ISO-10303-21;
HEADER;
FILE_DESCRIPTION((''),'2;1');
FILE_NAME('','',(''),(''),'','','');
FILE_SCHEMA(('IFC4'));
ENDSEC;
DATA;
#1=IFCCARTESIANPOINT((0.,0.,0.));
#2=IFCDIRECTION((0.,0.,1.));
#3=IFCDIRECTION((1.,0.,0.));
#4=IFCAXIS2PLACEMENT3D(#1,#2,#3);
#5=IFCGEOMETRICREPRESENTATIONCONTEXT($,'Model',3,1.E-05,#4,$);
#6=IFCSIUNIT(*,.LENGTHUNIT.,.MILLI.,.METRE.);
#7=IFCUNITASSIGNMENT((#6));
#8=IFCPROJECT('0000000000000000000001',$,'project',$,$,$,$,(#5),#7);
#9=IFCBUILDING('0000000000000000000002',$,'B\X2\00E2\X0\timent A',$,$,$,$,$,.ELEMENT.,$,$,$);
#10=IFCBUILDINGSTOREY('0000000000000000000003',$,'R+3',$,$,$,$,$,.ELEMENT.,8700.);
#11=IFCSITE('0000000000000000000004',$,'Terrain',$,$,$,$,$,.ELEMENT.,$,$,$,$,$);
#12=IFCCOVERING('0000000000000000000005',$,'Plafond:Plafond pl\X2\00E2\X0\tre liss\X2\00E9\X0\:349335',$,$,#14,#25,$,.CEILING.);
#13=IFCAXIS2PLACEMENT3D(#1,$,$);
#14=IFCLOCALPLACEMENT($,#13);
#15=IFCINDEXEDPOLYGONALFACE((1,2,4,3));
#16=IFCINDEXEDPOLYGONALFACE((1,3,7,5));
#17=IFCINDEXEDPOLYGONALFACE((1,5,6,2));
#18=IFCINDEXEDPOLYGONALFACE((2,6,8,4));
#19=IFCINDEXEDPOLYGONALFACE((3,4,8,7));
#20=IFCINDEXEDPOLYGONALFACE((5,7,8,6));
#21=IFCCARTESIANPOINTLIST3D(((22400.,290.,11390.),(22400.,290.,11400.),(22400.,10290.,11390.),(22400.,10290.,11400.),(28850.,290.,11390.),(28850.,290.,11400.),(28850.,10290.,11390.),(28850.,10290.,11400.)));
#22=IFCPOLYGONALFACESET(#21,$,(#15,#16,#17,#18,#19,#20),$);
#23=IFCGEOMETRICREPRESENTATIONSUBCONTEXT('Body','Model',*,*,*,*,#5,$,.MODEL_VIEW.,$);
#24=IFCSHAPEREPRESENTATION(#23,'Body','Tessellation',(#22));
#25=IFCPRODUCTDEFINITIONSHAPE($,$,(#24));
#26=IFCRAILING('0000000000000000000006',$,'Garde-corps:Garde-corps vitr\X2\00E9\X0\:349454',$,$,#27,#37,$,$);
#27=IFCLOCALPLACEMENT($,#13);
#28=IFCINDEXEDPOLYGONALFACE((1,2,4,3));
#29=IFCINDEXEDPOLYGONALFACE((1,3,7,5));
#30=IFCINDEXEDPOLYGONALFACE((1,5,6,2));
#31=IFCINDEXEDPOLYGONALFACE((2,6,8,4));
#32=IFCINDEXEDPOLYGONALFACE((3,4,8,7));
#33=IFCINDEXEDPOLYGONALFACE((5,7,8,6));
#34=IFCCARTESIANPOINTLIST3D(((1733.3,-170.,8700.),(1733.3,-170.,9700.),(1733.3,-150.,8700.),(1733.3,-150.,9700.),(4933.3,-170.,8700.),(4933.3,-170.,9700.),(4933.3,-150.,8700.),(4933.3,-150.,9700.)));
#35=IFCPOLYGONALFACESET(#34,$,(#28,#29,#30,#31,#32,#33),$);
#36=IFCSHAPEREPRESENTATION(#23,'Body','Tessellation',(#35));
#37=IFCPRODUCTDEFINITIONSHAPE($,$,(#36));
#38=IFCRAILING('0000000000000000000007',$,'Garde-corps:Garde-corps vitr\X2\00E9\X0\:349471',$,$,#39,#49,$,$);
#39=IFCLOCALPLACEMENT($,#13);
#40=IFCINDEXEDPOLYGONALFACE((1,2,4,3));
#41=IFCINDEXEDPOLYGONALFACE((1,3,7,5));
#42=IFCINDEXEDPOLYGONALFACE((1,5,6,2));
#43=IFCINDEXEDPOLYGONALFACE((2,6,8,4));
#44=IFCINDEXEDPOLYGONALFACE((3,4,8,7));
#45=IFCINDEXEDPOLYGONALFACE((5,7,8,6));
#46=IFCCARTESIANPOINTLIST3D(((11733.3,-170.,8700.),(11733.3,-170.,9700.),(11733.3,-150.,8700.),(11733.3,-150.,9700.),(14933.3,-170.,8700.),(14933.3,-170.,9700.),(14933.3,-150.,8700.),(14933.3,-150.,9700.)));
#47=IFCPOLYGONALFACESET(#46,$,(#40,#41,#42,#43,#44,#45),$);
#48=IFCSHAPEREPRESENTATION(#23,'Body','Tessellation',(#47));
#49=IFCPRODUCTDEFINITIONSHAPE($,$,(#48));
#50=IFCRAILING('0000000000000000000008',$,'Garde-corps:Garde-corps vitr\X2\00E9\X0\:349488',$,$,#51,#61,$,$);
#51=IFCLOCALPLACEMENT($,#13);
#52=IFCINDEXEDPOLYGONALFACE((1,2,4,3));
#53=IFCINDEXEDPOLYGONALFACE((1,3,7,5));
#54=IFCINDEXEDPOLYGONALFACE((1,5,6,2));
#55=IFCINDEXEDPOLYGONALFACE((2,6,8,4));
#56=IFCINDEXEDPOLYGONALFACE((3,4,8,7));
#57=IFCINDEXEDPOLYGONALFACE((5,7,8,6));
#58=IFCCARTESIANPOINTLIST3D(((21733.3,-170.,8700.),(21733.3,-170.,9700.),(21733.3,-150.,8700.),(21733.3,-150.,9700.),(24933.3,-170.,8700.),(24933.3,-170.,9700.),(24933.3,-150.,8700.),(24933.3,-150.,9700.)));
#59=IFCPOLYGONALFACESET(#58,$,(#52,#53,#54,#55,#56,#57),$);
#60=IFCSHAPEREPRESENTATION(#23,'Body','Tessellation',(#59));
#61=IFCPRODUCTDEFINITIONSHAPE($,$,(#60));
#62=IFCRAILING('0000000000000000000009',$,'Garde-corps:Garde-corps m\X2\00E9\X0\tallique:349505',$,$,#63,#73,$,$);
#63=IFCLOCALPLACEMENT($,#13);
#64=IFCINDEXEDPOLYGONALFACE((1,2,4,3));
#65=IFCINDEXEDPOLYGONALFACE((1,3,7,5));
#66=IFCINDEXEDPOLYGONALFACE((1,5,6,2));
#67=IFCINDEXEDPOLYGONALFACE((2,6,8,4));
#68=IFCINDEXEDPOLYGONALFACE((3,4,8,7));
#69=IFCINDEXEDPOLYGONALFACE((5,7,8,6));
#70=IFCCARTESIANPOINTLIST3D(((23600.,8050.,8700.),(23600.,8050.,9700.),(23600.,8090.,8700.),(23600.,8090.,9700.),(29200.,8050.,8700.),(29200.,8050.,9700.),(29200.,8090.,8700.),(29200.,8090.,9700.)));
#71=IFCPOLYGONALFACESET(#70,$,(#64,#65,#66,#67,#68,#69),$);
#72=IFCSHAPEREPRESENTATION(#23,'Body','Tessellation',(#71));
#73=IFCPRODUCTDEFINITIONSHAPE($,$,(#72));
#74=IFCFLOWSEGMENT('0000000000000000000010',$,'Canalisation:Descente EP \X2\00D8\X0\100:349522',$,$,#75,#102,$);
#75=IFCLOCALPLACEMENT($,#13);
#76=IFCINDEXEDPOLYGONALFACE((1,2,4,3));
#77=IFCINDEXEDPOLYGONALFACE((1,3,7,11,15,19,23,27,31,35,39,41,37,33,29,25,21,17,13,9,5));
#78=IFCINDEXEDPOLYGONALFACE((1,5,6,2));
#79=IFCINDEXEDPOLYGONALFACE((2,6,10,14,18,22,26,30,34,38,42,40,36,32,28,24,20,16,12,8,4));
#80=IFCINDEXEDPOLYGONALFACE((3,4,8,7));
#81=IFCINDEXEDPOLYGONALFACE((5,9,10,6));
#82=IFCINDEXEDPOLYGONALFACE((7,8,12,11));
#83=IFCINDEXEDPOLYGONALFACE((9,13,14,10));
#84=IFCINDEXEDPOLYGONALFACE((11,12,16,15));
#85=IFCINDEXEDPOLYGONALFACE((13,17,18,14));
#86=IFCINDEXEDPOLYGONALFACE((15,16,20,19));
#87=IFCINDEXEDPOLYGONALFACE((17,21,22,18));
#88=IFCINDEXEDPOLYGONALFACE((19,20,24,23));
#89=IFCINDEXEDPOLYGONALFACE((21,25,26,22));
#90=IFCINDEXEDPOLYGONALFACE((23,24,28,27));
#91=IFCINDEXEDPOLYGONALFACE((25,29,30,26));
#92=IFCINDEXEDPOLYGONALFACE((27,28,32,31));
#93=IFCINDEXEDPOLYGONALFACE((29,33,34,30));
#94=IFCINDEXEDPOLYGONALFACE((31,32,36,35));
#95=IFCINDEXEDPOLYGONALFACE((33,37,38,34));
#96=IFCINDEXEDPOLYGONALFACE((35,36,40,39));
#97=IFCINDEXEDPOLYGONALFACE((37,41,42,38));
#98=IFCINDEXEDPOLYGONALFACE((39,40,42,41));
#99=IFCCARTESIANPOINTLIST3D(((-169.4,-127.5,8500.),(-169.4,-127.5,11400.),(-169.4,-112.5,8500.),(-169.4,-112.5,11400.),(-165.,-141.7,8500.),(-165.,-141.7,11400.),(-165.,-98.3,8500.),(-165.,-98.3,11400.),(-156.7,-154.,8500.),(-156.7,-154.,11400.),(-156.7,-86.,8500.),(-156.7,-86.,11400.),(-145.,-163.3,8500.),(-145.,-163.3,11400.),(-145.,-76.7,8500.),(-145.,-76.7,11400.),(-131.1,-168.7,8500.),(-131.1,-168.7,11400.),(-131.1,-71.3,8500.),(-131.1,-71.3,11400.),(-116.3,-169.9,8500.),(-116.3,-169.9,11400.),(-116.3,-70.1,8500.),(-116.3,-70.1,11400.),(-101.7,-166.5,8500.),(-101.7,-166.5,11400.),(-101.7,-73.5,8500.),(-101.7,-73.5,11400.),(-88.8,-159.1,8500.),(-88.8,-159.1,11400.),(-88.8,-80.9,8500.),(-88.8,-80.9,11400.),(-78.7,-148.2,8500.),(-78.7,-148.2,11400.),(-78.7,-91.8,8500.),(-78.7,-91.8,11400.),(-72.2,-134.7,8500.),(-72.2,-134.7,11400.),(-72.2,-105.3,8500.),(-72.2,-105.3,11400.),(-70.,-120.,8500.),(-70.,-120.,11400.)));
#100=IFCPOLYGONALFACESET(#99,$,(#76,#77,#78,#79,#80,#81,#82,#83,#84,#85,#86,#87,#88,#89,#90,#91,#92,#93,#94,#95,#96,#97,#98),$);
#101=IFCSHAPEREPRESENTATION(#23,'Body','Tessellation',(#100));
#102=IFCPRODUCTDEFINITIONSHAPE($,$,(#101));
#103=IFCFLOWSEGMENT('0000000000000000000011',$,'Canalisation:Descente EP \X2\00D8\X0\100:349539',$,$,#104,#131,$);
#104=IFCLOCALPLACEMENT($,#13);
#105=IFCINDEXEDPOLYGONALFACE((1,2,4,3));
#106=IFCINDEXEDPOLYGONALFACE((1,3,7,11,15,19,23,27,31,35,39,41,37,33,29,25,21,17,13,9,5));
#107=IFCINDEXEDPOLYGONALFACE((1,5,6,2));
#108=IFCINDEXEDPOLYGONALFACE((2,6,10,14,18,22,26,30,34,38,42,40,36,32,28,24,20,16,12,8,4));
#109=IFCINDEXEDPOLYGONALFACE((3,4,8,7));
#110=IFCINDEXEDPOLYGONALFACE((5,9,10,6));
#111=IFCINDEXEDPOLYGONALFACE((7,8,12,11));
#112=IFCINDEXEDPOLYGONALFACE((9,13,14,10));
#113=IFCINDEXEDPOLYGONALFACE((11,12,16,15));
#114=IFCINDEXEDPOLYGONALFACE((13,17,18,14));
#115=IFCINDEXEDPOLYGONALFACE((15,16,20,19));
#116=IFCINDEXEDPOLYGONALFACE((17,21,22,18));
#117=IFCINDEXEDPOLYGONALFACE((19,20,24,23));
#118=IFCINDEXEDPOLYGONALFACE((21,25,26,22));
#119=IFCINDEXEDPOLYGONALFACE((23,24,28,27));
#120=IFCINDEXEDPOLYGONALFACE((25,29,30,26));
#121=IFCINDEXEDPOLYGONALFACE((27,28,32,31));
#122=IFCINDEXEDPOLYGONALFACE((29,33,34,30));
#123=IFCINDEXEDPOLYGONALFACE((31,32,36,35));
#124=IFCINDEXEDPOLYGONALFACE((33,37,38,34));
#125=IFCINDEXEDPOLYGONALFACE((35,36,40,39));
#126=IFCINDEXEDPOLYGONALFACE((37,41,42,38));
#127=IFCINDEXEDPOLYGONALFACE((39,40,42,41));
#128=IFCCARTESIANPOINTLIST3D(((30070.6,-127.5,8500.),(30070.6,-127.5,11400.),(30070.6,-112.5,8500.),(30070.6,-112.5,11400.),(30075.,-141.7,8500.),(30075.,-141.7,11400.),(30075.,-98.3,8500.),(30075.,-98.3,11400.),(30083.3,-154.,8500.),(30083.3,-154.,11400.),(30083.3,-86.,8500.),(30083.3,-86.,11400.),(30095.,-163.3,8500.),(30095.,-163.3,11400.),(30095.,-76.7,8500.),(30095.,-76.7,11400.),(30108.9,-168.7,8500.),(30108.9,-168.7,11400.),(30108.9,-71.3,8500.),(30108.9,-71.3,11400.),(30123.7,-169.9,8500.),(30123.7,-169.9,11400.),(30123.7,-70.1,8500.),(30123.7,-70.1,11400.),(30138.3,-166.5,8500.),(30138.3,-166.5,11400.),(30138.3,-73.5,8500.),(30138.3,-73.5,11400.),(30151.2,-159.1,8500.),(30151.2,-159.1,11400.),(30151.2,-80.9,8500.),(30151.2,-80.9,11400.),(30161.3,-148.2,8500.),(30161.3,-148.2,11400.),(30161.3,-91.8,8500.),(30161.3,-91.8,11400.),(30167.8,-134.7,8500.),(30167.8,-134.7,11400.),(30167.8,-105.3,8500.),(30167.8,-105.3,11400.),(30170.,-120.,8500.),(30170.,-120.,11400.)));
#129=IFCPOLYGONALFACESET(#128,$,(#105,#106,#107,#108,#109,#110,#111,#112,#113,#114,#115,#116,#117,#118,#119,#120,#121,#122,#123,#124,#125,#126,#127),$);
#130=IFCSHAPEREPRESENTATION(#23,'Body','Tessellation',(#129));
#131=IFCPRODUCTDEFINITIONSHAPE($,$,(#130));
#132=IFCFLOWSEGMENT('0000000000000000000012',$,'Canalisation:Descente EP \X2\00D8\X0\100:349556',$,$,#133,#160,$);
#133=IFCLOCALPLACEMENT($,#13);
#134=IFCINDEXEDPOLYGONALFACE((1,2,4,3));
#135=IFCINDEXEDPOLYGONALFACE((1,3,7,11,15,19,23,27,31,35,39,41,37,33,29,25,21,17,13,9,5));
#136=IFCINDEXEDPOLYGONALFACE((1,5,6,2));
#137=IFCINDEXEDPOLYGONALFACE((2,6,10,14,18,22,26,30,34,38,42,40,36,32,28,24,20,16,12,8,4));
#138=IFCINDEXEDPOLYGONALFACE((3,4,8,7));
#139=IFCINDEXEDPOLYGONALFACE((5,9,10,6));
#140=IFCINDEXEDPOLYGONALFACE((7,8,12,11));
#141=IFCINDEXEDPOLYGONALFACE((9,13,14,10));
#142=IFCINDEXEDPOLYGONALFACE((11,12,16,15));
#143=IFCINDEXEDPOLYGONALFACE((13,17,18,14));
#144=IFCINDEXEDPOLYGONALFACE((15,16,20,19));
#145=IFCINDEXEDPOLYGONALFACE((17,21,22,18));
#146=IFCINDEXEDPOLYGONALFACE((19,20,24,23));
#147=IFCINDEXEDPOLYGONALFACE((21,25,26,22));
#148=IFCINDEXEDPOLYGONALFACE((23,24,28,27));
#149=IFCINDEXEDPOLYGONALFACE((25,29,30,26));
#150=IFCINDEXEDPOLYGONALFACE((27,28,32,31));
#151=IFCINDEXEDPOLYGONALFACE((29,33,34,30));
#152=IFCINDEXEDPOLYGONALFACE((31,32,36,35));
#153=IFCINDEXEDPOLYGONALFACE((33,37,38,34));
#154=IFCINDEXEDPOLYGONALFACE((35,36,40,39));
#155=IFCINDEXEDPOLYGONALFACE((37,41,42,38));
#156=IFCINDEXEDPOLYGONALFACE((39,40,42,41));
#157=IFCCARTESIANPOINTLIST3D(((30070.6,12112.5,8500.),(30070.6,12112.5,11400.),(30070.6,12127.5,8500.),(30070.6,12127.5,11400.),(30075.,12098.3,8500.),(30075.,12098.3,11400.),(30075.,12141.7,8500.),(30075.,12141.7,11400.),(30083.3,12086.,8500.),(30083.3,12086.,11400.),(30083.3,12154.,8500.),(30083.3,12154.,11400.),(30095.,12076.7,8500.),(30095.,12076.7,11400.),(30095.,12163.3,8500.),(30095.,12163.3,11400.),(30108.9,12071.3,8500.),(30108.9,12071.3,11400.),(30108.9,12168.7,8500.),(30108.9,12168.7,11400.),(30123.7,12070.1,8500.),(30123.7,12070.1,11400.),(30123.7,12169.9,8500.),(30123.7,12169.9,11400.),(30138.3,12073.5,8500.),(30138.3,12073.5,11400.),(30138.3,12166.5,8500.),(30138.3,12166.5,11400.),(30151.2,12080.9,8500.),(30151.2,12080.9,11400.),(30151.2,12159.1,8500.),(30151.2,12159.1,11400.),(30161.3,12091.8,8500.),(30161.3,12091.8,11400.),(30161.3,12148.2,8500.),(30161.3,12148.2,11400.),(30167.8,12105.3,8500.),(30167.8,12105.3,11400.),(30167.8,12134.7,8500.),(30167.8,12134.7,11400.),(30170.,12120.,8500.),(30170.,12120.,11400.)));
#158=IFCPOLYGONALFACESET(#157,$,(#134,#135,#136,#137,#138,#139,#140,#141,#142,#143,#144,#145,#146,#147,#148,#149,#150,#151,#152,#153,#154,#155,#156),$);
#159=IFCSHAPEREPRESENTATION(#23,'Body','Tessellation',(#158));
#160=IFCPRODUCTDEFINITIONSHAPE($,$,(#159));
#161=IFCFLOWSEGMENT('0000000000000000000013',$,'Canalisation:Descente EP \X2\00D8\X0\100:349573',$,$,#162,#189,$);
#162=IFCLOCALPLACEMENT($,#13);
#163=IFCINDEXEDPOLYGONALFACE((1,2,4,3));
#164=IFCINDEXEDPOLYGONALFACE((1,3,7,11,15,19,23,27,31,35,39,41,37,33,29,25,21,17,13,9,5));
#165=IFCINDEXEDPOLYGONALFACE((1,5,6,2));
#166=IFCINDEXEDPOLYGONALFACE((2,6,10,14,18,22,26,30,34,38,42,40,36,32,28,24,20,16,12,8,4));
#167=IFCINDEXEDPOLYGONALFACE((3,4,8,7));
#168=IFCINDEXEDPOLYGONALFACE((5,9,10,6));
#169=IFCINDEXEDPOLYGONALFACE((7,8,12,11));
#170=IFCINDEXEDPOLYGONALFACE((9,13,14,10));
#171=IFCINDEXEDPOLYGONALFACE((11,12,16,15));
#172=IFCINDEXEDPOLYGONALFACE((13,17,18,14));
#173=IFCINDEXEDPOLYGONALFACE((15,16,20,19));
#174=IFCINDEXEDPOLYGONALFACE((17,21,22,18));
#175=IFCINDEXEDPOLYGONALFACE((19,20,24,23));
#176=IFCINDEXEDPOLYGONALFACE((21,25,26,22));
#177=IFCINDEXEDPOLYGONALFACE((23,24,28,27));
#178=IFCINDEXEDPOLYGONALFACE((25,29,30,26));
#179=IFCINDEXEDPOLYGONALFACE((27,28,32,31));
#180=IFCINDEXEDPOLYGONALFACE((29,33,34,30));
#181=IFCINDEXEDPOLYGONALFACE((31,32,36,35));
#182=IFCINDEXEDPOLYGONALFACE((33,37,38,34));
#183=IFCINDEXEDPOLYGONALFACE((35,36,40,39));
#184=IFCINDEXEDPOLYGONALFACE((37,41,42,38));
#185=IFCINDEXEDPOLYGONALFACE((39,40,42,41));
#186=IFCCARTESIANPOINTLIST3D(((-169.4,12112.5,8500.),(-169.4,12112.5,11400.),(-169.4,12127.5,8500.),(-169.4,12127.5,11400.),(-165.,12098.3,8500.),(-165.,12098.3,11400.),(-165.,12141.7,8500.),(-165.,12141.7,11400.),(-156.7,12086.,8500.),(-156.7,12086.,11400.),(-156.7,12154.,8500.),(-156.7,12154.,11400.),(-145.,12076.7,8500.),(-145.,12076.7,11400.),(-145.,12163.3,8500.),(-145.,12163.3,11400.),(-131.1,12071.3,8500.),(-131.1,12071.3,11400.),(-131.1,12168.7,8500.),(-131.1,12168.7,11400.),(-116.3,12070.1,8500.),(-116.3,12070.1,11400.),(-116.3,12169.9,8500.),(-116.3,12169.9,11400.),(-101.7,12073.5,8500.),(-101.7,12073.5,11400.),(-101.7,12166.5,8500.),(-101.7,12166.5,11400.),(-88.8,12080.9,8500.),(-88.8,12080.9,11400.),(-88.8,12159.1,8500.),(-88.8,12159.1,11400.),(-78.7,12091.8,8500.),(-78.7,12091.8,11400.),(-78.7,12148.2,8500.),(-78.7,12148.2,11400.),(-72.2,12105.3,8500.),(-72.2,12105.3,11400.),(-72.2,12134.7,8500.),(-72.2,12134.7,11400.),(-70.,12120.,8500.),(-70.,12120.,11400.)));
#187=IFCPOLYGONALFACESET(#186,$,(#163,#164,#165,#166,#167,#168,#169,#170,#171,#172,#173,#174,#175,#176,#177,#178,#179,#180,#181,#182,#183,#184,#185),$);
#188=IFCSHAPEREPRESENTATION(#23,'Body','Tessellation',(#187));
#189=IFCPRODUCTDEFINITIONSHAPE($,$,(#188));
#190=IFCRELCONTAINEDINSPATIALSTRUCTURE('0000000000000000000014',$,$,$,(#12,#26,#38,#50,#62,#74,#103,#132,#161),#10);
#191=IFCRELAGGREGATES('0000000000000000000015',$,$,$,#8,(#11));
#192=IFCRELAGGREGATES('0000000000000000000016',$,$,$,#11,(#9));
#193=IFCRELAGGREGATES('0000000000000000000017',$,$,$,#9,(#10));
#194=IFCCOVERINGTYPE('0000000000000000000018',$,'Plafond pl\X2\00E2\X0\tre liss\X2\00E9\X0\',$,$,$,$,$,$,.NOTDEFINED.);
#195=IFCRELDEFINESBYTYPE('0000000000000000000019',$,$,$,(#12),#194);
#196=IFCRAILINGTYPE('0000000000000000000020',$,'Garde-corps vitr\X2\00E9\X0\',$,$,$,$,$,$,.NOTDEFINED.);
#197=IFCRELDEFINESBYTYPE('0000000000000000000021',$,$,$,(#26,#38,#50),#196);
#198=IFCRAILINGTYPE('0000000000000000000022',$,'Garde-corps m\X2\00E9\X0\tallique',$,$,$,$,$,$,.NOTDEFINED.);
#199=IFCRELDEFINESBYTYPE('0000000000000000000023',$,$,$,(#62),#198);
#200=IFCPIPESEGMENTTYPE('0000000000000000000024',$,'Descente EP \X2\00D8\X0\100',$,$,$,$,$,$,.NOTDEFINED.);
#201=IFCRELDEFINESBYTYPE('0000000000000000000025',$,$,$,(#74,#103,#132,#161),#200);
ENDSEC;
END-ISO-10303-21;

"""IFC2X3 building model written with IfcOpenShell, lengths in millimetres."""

from ifc_helpers import new_model, si_unit, frame, frame_2d, origin_with_axes, origin_2d, place, context, subcontext, project, spatial, rectangle, circle, extrude, type_object, element, save


model = new_model("IFC2X3")

# Units and contexts
model_context = context("Model", 3, precision=1e-05, world=origin_with_axes())
body_context = subcontext(model_context, "Body", "Model", "MODEL_VIEW")
ifc_project = project(units=[si_unit("LENGTHUNIT", "METRE", prefix="MILLI")], contexts=[model_context])

# Site, building, storey
site = spatial("IfcSite", under=ifc_project, Name="Terrain", CompositionType="ELEMENT")
building = spatial("IfcBuilding", under=site, Name="Bâtiment A", CompositionType="ELEMENT")
storey = spatial("IfcBuildingStorey", under=building, Name="R+3", CompositionType="ELEMENT", Elevation=8700.0)

# Covering
covering_type_1 = type_object("IfcCoveringType", Name="Plafond plâtre lissé", PredefinedType="NOTDEFINED")
covering_1_placement = place(None, origin_with_axes())
element("IfcCovering", 1, at=covering_1_placement, inside=storey, type_object=covering_type_1, Name="Plafond:Plafond plâtre lissé:349335", PredefinedType="CEILING", context=body_context, shape_type="SweptSolid", body=[
    extrude(rectangle(XDim=6450.0, YDim=10000.0, at=frame_2d((25625.0, 5290.0))), frame((0.0, 0.0, 11390.0), z_axis=(0.0, 0.0, 1.0), x_axis=(1.0, 0.0, 0.0)), (0.0, 0.0, 1.0), 10.0),
])

# Railings
railing_type_1 = type_object("IfcRailingType", Name="Garde-corps vitré", PredefinedType="NOTDEFINED")
railing_1_placement = place(None, origin_with_axes())
element("IfcRailing", 2, at=railing_1_placement, inside=storey, type_object=railing_type_1, Name="Garde-corps:Garde-corps vitré:349454", context=body_context, shape_type="SweptSolid", body=[
    extrude(rectangle(XDim=3200.0, YDim=20.0, at=frame_2d((3333.3, -160.0))), frame((0.0, 0.0, 8700.0), z_axis=(0.0, 0.0, 1.0), x_axis=(1.0, 0.0, 0.0)), (0.0, 0.0, 1.0), 1000.0),
])
railing_2_placement = place(None, origin_with_axes())
element("IfcRailing", 3, at=railing_2_placement, inside=storey, type_object=railing_type_1, Name="Garde-corps:Garde-corps vitré:349471", context=body_context, shape_type="SweptSolid", body=[
    extrude(rectangle(XDim=3200.0, YDim=20.0, at=frame_2d((13333.3, -160.0))), frame((0.0, 0.0, 8700.0), z_axis=(0.0, 0.0, 1.0), x_axis=(1.0, 0.0, 0.0)), (0.0, 0.0, 1.0), 1000.0),
])
railing_3_placement = place(None, origin_with_axes())
element("IfcRailing", 4, at=railing_3_placement, inside=storey, type_object=railing_type_1, Name="Garde-corps:Garde-corps vitré:349488", context=body_context, shape_type="SweptSolid", body=[
    extrude(rectangle(XDim=3200.0, YDim=20.0, at=frame_2d((23333.3, -160.0))), frame((0.0, 0.0, 8700.0), z_axis=(0.0, 0.0, 1.0), x_axis=(1.0, 0.0, 0.0)), (0.0, 0.0, 1.0), 1000.0),
])
railing_type_2 = type_object("IfcRailingType", Name="Garde-corps métallique", PredefinedType="NOTDEFINED")
railing_4_placement = place(None, origin_with_axes())
element("IfcRailing", 5, at=railing_4_placement, inside=storey, type_object=railing_type_2, Name="Garde-corps:Garde-corps métallique:349505", context=body_context, shape_type="SweptSolid", body=[
    extrude(rectangle(XDim=5600.0, YDim=40.0, at=frame_2d((26400.0, 8070.0))), frame((0.0, 0.0, 8700.0), z_axis=(0.0, 0.0, 1.0), x_axis=(1.0, 0.0, 0.0)), (0.0, 0.0, 1.0), 1000.0),
])

# Flow segments
pipe_segment_type = type_object("IfcPipeSegmentType", Name="Descente EP Ø100", PredefinedType="NOTDEFINED")
flow_segment_1_placement = place(None, origin_with_axes())
element("IfcFlowSegment", 6, at=flow_segment_1_placement, inside=storey, type_object=pipe_segment_type, Name="Canalisation:Descente EP Ø100:349522", context=body_context, shape_type="SweptSolid", body=[
    extrude(circle(Radius=50.0, at=origin_2d()), frame((-120.0, -120.0, 8500.0), z_axis=(0.0, 0.0, 1.0), x_axis=(1.0, 0.0, 0.0)), (0.0, 0.0, 1.0), 2900.0),
])
flow_segment_2_placement = place(None, origin_with_axes())
element("IfcFlowSegment", 7, at=flow_segment_2_placement, inside=storey, type_object=pipe_segment_type, Name="Canalisation:Descente EP Ø100:349539", context=body_context, shape_type="SweptSolid", body=[
    extrude(circle(Radius=50.0, at=origin_2d()), frame((30120.0, -120.0, 8500.0), z_axis=(0.0, 0.0, 1.0), x_axis=(1.0, 0.0, 0.0)), (0.0, 0.0, 1.0), 2900.0),
])
flow_segment_3_placement = place(None, origin_with_axes())
element("IfcFlowSegment", 8, at=flow_segment_3_placement, inside=storey, type_object=pipe_segment_type, Name="Canalisation:Descente EP Ø100:349556", context=body_context, shape_type="SweptSolid", body=[
    extrude(circle(Radius=50.0, at=origin_2d()), frame((30120.0, 12120.0, 8500.0), z_axis=(0.0, 0.0, 1.0), x_axis=(1.0, 0.0, 0.0)), (0.0, 0.0, 1.0), 2900.0),
])
flow_segment_4_placement = place(None, origin_with_axes())
element("IfcFlowSegment", 9, at=flow_segment_4_placement, inside=storey, type_object=pipe_segment_type, Name="Canalisation:Descente EP Ø100:349573", context=body_context, shape_type="SweptSolid", body=[
    extrude(circle(Radius=50.0, at=origin_2d()), frame((-120.0, 12120.0, 8500.0), z_axis=(0.0, 0.0, 1.0), x_axis=(1.0, 0.0, 0.0)), (0.0, 0.0, 1.0), 2900.0),
])

save(model, "model.ifc")
